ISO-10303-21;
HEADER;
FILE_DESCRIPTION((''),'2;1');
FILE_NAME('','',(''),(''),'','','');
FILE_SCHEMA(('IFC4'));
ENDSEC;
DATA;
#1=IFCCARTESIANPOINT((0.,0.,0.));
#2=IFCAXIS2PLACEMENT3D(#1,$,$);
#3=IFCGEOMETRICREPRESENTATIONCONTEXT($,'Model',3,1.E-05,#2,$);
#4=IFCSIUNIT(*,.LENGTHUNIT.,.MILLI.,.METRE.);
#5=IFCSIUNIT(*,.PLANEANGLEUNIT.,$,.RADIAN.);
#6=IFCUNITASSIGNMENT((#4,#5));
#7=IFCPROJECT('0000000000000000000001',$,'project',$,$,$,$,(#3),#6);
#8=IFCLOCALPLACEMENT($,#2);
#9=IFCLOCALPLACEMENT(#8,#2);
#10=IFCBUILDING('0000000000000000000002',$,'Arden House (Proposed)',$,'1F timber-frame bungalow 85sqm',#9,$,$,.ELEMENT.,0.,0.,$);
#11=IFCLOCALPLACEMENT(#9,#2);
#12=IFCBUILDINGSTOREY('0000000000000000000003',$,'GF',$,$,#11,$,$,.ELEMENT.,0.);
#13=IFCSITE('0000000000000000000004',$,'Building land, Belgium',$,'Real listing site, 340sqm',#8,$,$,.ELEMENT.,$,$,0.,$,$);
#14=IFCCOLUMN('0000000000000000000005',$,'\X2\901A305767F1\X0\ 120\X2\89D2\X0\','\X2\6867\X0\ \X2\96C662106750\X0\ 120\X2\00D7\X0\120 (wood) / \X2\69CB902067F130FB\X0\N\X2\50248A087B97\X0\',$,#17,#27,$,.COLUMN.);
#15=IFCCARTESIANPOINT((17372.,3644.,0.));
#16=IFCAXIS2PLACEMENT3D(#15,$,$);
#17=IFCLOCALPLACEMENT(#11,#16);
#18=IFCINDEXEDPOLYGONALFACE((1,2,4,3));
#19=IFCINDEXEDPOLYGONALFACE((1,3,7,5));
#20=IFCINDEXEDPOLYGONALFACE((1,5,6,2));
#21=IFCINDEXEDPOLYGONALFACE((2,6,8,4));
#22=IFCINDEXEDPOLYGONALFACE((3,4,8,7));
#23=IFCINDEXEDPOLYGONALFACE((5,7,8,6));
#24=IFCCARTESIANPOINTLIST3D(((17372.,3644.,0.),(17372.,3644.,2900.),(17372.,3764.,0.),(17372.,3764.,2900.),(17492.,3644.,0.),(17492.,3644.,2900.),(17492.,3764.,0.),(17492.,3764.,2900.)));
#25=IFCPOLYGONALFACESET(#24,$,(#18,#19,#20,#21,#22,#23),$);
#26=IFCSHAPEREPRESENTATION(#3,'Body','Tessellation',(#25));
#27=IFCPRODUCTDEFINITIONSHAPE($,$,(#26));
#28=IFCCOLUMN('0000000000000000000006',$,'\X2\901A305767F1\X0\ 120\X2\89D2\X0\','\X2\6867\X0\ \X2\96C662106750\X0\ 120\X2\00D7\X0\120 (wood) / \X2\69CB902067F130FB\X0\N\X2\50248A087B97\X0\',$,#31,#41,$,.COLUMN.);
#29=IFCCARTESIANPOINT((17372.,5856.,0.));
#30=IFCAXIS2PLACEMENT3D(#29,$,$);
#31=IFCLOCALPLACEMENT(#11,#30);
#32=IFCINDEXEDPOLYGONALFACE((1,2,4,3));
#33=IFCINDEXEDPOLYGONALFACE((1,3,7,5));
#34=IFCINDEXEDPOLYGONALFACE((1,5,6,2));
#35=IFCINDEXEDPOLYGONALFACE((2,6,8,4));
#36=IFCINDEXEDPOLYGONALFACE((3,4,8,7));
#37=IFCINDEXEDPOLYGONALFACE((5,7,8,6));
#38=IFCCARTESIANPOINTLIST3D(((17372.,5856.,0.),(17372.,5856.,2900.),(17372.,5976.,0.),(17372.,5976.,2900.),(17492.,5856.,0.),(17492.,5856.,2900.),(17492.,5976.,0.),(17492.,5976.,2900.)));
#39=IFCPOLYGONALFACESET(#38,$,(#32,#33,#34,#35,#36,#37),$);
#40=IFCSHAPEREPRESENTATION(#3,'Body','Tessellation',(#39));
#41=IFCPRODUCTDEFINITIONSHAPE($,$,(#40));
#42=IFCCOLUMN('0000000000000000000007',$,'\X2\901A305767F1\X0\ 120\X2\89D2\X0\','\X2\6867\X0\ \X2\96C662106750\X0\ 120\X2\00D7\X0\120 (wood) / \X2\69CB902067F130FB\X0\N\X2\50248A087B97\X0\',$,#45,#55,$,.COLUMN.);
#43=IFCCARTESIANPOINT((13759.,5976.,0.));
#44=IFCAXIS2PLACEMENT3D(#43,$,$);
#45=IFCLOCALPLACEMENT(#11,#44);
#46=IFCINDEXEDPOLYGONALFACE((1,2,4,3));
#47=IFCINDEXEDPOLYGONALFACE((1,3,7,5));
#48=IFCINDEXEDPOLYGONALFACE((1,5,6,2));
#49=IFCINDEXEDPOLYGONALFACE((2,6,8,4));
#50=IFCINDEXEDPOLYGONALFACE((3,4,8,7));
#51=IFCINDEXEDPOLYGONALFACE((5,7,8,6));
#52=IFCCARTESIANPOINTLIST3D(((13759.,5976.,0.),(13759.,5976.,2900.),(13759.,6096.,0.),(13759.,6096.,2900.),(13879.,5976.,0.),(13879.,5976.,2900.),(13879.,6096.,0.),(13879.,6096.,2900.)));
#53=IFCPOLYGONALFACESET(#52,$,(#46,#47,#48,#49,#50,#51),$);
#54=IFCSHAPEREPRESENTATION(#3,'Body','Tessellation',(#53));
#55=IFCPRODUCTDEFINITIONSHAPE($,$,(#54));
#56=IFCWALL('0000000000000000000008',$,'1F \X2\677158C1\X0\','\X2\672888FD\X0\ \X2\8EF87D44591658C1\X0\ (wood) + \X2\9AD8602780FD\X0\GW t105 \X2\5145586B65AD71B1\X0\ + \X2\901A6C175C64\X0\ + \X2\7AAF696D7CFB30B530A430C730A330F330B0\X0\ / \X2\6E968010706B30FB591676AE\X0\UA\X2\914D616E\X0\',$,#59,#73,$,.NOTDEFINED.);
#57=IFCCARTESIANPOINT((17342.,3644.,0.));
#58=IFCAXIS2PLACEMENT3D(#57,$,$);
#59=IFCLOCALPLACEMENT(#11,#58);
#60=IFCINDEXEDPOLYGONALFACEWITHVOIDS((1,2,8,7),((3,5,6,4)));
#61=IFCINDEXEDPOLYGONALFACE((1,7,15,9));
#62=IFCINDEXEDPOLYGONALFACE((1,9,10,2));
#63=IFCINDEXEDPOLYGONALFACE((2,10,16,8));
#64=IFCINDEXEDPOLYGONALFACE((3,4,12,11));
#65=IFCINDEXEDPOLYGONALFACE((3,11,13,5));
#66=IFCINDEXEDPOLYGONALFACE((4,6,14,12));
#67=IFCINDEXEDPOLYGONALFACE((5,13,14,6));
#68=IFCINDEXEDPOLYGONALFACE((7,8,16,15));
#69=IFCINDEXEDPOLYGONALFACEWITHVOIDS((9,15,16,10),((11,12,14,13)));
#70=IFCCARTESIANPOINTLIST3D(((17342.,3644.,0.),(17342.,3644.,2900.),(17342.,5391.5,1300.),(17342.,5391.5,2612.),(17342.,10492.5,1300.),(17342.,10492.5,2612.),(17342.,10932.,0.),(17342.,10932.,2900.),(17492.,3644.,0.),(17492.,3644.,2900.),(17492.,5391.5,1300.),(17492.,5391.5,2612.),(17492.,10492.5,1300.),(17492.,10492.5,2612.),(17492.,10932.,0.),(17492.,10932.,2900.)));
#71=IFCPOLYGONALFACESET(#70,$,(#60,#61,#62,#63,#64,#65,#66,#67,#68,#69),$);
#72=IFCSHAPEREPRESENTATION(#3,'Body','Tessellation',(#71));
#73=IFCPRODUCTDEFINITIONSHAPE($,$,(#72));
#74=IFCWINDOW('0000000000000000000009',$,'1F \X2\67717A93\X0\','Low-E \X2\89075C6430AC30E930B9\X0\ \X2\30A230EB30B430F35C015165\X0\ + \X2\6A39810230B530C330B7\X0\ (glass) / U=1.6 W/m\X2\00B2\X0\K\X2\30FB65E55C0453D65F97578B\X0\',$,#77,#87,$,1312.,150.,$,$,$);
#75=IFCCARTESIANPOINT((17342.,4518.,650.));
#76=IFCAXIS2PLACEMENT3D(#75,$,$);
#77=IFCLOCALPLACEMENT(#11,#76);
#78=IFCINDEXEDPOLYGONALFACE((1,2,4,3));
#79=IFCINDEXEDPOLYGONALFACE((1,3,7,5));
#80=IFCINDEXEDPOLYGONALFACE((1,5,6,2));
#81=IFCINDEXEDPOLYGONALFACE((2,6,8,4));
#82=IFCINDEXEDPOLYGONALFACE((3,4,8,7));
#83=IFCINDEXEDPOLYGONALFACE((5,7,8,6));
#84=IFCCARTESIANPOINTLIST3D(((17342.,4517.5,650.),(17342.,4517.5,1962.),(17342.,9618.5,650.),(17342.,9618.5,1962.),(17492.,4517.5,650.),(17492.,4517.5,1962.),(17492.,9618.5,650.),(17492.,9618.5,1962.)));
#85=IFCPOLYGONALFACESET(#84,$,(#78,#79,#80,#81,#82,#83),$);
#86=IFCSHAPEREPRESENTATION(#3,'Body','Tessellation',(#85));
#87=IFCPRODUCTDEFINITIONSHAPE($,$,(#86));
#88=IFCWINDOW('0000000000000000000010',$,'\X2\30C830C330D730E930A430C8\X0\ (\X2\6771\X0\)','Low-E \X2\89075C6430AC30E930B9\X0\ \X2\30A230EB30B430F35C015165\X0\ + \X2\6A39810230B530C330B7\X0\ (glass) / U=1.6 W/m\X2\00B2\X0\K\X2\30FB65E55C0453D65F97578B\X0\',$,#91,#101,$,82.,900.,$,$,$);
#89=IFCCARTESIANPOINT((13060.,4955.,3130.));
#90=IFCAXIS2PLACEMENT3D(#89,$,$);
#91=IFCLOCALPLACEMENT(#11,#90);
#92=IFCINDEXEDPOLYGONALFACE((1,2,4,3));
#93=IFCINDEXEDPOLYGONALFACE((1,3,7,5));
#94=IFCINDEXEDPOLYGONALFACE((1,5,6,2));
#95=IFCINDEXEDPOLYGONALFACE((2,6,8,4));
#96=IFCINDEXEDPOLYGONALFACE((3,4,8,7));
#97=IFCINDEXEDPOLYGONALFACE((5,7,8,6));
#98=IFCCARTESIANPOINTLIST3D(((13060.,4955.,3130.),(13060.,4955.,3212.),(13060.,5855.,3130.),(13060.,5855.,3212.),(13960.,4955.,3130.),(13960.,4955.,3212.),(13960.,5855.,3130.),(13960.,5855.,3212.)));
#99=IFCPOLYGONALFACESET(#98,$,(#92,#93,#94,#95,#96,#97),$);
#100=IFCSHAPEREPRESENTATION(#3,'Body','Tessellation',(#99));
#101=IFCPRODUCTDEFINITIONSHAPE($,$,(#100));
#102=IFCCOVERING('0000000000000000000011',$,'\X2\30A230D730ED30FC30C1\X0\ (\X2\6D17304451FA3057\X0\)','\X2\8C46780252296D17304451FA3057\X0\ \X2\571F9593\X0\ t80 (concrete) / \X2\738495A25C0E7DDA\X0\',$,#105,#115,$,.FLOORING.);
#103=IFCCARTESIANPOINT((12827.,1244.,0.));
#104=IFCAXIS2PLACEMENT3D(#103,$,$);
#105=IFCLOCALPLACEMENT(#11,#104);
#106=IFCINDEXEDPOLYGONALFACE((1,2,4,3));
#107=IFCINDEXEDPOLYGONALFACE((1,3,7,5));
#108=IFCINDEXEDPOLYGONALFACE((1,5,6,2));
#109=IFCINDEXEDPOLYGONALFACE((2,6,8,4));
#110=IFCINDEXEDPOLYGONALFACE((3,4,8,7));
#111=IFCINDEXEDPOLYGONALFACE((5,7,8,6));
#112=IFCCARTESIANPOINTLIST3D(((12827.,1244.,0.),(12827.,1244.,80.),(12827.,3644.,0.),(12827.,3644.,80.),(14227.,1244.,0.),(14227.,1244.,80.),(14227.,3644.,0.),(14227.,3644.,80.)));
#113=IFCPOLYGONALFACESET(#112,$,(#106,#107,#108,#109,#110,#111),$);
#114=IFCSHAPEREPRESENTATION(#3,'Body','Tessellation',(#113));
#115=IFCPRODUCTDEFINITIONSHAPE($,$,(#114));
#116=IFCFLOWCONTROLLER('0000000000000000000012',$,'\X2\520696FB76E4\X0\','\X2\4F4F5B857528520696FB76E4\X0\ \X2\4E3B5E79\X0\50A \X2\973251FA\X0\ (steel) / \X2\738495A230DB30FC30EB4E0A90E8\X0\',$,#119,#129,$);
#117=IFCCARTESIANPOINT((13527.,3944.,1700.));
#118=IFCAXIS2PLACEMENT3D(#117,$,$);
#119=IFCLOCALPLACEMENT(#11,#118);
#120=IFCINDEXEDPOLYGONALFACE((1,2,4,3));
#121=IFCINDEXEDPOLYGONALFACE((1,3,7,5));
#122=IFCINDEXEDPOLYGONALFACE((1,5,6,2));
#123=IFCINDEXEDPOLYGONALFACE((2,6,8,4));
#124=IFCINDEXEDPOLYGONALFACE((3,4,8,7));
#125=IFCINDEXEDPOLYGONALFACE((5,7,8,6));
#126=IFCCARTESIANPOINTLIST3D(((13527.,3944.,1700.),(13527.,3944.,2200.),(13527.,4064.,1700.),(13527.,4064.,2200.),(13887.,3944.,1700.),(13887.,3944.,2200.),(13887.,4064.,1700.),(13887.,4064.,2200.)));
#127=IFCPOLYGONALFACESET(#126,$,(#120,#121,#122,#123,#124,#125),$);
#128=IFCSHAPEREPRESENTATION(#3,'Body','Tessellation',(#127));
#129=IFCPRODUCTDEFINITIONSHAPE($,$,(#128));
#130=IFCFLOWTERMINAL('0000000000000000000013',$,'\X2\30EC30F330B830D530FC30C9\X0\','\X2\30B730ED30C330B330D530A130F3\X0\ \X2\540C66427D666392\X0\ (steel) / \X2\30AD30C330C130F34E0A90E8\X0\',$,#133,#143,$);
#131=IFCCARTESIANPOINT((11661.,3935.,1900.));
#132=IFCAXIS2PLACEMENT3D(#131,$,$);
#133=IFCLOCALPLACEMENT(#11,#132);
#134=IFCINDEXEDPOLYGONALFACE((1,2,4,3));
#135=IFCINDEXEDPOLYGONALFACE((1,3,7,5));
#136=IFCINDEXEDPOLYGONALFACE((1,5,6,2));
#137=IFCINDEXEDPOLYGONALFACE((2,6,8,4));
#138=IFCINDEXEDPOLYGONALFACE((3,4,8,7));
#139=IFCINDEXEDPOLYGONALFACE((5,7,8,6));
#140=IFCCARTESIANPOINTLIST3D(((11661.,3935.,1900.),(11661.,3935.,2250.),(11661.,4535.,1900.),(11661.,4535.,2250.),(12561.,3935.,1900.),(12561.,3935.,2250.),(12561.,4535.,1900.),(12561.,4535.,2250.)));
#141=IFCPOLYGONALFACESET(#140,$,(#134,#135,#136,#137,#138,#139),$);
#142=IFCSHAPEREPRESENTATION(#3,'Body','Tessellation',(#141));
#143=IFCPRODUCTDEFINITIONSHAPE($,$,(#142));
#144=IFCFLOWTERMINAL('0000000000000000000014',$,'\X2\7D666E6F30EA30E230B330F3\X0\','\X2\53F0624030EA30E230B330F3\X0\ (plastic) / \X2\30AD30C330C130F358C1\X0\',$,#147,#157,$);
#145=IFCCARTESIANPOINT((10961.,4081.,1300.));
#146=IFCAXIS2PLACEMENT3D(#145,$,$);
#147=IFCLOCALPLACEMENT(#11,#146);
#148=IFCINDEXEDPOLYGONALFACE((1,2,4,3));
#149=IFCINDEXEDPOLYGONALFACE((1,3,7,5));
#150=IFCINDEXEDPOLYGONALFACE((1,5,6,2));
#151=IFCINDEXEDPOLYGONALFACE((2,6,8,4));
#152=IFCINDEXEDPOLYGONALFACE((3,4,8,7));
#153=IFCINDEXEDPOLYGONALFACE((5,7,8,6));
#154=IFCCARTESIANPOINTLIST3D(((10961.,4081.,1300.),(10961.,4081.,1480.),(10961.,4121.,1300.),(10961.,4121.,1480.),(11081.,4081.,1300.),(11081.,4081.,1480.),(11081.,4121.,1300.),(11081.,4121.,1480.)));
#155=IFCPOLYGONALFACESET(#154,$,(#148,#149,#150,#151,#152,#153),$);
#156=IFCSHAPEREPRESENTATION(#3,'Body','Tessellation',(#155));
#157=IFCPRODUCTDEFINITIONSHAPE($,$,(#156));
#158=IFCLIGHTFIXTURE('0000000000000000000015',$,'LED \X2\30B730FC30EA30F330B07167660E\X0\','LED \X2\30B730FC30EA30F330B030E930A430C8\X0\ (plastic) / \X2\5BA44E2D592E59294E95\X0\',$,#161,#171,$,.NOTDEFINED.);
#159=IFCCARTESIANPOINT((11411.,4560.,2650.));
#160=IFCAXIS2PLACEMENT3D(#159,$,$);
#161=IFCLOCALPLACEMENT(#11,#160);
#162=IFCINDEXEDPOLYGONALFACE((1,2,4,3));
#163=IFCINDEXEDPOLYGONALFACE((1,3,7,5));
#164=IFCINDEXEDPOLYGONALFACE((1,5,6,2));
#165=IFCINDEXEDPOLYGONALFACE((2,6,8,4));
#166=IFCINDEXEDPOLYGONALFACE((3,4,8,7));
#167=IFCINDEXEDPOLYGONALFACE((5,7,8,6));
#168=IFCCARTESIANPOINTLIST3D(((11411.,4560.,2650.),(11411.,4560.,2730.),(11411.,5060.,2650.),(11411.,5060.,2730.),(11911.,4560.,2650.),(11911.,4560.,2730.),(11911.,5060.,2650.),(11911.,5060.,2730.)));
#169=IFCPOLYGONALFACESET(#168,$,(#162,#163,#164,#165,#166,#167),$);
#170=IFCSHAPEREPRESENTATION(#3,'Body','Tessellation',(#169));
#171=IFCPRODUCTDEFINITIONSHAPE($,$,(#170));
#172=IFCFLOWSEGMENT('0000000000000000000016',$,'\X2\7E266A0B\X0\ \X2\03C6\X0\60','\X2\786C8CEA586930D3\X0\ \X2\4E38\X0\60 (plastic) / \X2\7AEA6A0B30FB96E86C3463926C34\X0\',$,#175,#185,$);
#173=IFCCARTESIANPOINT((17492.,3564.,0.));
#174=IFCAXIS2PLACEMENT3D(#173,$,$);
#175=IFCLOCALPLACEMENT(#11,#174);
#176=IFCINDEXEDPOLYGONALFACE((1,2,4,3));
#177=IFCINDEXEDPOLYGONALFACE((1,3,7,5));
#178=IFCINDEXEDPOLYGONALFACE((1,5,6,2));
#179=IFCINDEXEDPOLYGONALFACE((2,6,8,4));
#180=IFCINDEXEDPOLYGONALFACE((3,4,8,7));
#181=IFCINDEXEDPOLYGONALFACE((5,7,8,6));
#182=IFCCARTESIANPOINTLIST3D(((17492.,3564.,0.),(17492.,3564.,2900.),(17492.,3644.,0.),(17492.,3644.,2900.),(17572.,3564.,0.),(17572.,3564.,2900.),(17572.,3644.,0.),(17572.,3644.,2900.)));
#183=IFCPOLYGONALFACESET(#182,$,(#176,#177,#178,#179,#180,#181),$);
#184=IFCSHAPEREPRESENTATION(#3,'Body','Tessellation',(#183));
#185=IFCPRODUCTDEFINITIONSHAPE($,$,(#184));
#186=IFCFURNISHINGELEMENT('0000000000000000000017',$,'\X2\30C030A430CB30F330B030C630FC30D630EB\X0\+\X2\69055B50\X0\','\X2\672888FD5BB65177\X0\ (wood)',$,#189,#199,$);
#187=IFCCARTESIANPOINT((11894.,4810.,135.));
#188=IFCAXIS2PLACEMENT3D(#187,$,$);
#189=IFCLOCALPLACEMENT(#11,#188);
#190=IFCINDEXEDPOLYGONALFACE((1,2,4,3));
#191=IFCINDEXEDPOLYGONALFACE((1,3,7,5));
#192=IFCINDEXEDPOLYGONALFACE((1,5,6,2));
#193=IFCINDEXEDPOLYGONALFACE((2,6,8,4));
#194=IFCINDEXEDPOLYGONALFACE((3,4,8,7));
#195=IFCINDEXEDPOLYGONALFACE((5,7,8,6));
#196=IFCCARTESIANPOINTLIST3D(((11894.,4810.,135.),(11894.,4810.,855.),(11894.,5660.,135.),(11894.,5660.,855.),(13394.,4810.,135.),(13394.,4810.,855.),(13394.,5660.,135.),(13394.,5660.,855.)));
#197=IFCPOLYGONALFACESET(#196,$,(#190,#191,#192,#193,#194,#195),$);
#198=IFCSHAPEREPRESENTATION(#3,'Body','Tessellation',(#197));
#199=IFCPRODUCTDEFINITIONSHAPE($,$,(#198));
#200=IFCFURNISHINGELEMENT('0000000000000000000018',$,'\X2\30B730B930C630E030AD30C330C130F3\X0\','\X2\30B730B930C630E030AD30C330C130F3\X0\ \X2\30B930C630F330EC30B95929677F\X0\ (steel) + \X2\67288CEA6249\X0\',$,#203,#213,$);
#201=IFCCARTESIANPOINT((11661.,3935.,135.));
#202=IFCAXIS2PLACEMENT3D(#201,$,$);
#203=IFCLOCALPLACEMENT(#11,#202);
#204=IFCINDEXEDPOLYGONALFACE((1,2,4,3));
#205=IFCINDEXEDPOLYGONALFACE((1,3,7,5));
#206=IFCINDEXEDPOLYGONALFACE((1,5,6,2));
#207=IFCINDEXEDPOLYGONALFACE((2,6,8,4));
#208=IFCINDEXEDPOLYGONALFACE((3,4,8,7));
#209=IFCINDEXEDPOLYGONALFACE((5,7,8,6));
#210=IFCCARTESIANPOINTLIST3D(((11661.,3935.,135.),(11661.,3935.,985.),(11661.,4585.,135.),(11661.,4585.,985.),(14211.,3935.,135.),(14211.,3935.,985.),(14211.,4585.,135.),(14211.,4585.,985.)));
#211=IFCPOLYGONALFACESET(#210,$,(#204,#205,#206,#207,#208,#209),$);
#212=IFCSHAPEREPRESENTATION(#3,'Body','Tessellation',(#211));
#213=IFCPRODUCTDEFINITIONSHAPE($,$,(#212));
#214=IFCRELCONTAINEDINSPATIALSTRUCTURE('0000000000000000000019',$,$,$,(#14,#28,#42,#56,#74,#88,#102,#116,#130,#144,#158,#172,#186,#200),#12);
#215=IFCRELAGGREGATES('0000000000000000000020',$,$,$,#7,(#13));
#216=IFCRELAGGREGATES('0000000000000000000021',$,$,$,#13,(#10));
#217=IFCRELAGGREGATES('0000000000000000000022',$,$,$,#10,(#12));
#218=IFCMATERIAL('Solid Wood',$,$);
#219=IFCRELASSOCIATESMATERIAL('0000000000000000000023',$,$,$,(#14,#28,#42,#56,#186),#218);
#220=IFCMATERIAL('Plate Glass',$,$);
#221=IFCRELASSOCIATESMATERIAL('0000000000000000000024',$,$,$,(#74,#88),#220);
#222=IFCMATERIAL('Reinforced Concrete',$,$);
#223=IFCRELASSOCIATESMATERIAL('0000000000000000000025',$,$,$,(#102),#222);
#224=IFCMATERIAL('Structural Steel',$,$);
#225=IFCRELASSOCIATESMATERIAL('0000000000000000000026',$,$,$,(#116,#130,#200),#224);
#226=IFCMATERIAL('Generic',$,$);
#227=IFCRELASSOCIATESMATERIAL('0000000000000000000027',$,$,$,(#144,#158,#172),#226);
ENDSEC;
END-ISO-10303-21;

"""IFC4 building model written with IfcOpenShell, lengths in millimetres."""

from ifc_helpers import new_model, si_unit, frame, frame_2d, origin, place, context, project, spatial, rectangle, extrude, material, element, fill, save


model = new_model("IFC4")

# Units and contexts
model_context = context("Model", 3, precision=1e-05, world=origin())
ifc_project = project(units=[si_unit("LENGTHUNIT", "METRE", prefix="MILLI"), si_unit("PLANEANGLEUNIT", "RADIAN")], contexts=[model_context])

# Site, building, storey
site_placement = place(None, origin())
site = spatial("IfcSite", under=ifc_project, at=site_placement, Name="Building land, Belgium", ObjectType="Real listing site, 340sqm", CompositionType="ELEMENT", RefElevation=0.0)
building_placement = place(site_placement, origin())
building = spatial("IfcBuilding", under=site, at=building_placement, Name="Arden House (Proposed)", ObjectType="1F timber-frame bungalow 85sqm", CompositionType="ELEMENT", ElevationOfRefHeight=0.0, ElevationOfTerrain=0.0)
storey_placement = place(building_placement, origin())
storey = spatial("IfcBuildingStorey", under=building, at=storey_placement, Name="GF", CompositionType="ELEMENT", Elevation=0.0)

# Columns
ifc_material_1 = material(Name="Solid Wood")
column_1_placement = place(storey_placement, frame((17372.0, 3644.0, 0.0)))
element("IfcColumn", 1, at=column_1_placement, inside=storey, material=ifc_material_1, Name="通し柱 120角", Description="桧 集成材 120×120 (wood) / 構造柱・N値計算", PredefinedType="COLUMN", context=model_context, shape_type="SweptSolid", body=[
    extrude(rectangle(XDim=120.0, YDim=120.0, at=frame_2d((60.0, 60.0))), frame((17372.0, 3644.0, 0.0)), (0.0, 0.0, 1.0), 2900.0),
])
column_2_placement = place(storey_placement, frame((17372.0, 5856.0, 0.0)))
element("IfcColumn", 2, at=column_2_placement, inside=storey, material=ifc_material_1, Name="通し柱 120角", Description="桧 集成材 120×120 (wood) / 構造柱・N値計算", PredefinedType="COLUMN", context=model_context, shape_type="SweptSolid", body=[
    extrude(rectangle(XDim=120.0, YDim=120.0, at=frame_2d((60.0, 60.0))), frame((17372.0, 5856.0, 0.0)), (0.0, 0.0, 1.0), 2900.0),
])
column_3_placement = place(storey_placement, frame((13759.0, 5976.0, 0.0)))
element("IfcColumn", 3, at=column_3_placement, inside=storey, material=ifc_material_1, Name="通し柱 120角", Description="桧 集成材 120×120 (wood) / 構造柱・N値計算", PredefinedType="COLUMN", context=model_context, shape_type="SweptSolid", body=[
    extrude(rectangle(XDim=120.0, YDim=120.0, at=frame_2d((60.0, 60.0))), frame((13759.0, 5976.0, 0.0)), (0.0, 0.0, 1.0), 2900.0),
])

# Wall, opening, window
wall_1_placement = place(storey_placement, frame((17342.0, 3644.0, 0.0)))
wall_1 = element("IfcWall", 4, at=wall_1_placement, inside=storey, material=ifc_material_1, Name="1F 東壁", Description="木製 軸組外壁 (wood) + 高性能GW t105 充填断熱 + 通気層 + 窯業系サイディング / 準耐火・外皮UA配慮", PredefinedType="NOTDEFINED", context=model_context, shape_type="SweptSolid", body=[
    extrude(rectangle(XDim=150.0, YDim=7288.0, at=frame_2d((75.0, 3644.0))), frame((17342.0, 3644.0, 0.0)), (0.0, 0.0, 1.0), 2900.0),
])
opening_1_placement = place(storey_placement, frame((17342.0, 4518.0, 650.0)))
opening_1 = element("IfcOpeningElement", 5, at=opening_1_placement, cuts=wall_1, PredefinedType="NOTDEFINED", context=model_context, shape_type="SweptSolid", body=[
    extrude(rectangle(XDim=150.0, YDim=5101.0, at=frame_2d((75.0, 2550.0))), frame((17342.0, 4518.0, 650.0)), (0.0, 0.0, 1.0), 1312.0),
])
ifc_material_2 = material(Name="Plate Glass")
window_1_placement = place(storey_placement, frame((17342.0, 4518.0, 650.0)))
window_1 = element("IfcWindow", 6, at=window_1_placement, inside=storey, material=ifc_material_2, Name="1F 東窓", Description="Low-E 複層ガラス アルゴン封入 + 樹脂サッシ (glass) / U=1.6 W/m²K・日射取得型", OverallHeight=1312.0, OverallWidth=150.0, context=model_context, shape_type="SweptSolid", body=[
    extrude(rectangle(XDim=150.0, YDim=5101.0, at=frame_2d((75.0, 2550.0))), frame((17342.0, 4518.0, 650.0)), (0.0, 0.0, 1.0), 1312.0),
])
fill(opening_1, window_1)

# Window
window_2_placement = place(storey_placement, frame((13060.0, 4955.0, 3130.0)))
element("IfcWindow", 7, at=window_2_placement, inside=storey, material=ifc_material_2, Name="トップライト (東)", Description="Low-E 複層ガラス アルゴン封入 + 樹脂サッシ (glass) / U=1.6 W/m²K・日射取得型", OverallHeight=82.0, OverallWidth=900.0, context=model_context, shape_type="SweptSolid", body=[
    extrude(rectangle(XDim=900.0, YDim=900.0, at=frame_2d((450.0, 450.0))), frame((13060.0, 4955.0, 3130.0)), (0.0, 0.0, 1.0), 82.0),
])

# Shared definitions
ifc_material_3 = material(Name="Structural Steel")

# Covering
ifc_material_4 = material(Name="Reinforced Concrete")
covering_placement = place(storey_placement, frame((12827.0, 1244.0, 0.0)))
element("IfcCovering", 8, at=covering_placement, inside=storey, material=ifc_material_4, Name="アプローチ (洗い出し)", Description="豆砂利洗い出し 土間 t80 (concrete) / 玄関導線", PredefinedType="FLOORING", context=model_context, shape_type="SweptSolid", body=[
    extrude(rectangle(XDim=1400.0, YDim=2400.0, at=frame_2d((700.0, 1200.0))), frame((12827.0, 1244.0, 0.0)), (0.0, 0.0, 1.0), 80.0),
])

# Flow controller
flow_controller_placement = place(storey_placement, frame((13527.0, 3944.0, 1700.0)))
element("IfcFlowController", 9, at=flow_controller_placement, inside=storey, material=ifc_material_3, Name="分電盤", Description="住宅用分電盤 主幹50A 露出 (steel) / 玄関ホール上部", context=model_context, shape_type="SweptSolid", body=[
    extrude(rectangle(XDim=360.0, YDim=120.0, at=frame_2d((180.0, 60.0))), frame((13527.0, 3944.0, 1700.0)), (0.0, 0.0, 1.0), 500.0),
])

# Flow terminals
flow_terminal_1_placement = place(storey_placement, frame((11661.0, 3935.0, 1900.0)))
element("IfcFlowTerminal", 10, at=flow_terminal_1_placement, inside=storey, material=ifc_material_3, Name="レンジフード", Description="シロッコファン 同時給排 (steel) / キッチン上部", context=model_context, shape_type="SweptSolid", body=[
    extrude(rectangle(XDim=900.0, YDim=600.0, at=frame_2d((450.0, 300.0))), frame((11661.0, 3935.0, 1900.0)), (0.0, 0.0, 1.0), 350.0),
])
ifc_material_5 = material(Name="Generic")
flow_terminal_2_placement = place(storey_placement, frame((10961.0, 4081.0, 1300.0)))
element("IfcFlowTerminal", 11, at=flow_terminal_2_placement, inside=storey, material=ifc_material_5, Name="給湯リモコン", Description="台所リモコン (plastic) / キッチン壁", context=model_context, shape_type="SweptSolid", body=[
    extrude(rectangle(XDim=120.0, YDim=40.0, at=frame_2d((60.0, 20.0))), frame((10961.0, 4081.0, 1300.0)), (0.0, 0.0, 1.0), 180.0),
])

# Light fixture
light_fixture_placement = place(storey_placement, frame((11411.0, 4560.0, 2650.0)))
element("IfcLightFixture", 12, at=light_fixture_placement, inside=storey, material=ifc_material_5, Name="LED シーリング照明", Description="LED シーリングライト (plastic) / 室中央天井", PredefinedType="NOTDEFINED", context=model_context, shape_type="SweptSolid", body=[
    extrude(rectangle(XDim=500.0, YDim=500.0, at=frame_2d((250.0, 250.0))), frame((11411.0, 4560.0, 2650.0)), (0.0, 0.0, 1.0), 80.0),
])

# Flow segment
flow_segment_placement = place(storey_placement, frame((17492.0, 3564.0, 0.0)))
element("IfcFlowSegment", 13, at=flow_segment_placement, inside=storey, material=ifc_material_5, Name="縦樋 φ60", Description="硬質塩ビ 丸60 (plastic) / 竪樋・雨水排水", context=model_context, shape_type="SweptSolid", body=[
    extrude(rectangle(XDim=80.0, YDim=80.0, at=frame_2d((40.0, 40.0))), frame((17492.0, 3564.0, 0.0)), (0.0, 0.0, 1.0), 2900.0),
])

# Furnishing elements
furnishing_1_placement = place(storey_placement, frame((11894.0, 4810.0, 135.0)))
element("IfcFurnishingElement", 14, at=furnishing_1_placement, inside=storey, material=ifc_material_1, Name="ダイニングテーブル+椅子", Description="木製家具 (wood)", context=model_context, shape_type="SweptSolid", body=[
    extrude(rectangle(XDim=1500.0, YDim=850.0, at=frame_2d((750.0, 425.0))), frame((11894.0, 4810.0, 135.0)), (0.0, 0.0, 1.0), 720.0),
])
furnishing_2_placement = place(storey_placement, frame((11661.0, 3935.0, 135.0)))
element("IfcFurnishingElement", 15, at=furnishing_2_placement, inside=storey, material=ifc_material_3, Name="システムキッチン", Description="システムキッチン ステンレス天板 (steel) + 木質扉", context=model_context, shape_type="SweptSolid", body=[
    extrude(rectangle(XDim=2550.0, YDim=650.0, at=frame_2d((1275.0, 325.0))), frame((11661.0, 3935.0, 135.0)), (0.0, 0.0, 1.0), 850.0),
])

save(model, "model.ifc")
